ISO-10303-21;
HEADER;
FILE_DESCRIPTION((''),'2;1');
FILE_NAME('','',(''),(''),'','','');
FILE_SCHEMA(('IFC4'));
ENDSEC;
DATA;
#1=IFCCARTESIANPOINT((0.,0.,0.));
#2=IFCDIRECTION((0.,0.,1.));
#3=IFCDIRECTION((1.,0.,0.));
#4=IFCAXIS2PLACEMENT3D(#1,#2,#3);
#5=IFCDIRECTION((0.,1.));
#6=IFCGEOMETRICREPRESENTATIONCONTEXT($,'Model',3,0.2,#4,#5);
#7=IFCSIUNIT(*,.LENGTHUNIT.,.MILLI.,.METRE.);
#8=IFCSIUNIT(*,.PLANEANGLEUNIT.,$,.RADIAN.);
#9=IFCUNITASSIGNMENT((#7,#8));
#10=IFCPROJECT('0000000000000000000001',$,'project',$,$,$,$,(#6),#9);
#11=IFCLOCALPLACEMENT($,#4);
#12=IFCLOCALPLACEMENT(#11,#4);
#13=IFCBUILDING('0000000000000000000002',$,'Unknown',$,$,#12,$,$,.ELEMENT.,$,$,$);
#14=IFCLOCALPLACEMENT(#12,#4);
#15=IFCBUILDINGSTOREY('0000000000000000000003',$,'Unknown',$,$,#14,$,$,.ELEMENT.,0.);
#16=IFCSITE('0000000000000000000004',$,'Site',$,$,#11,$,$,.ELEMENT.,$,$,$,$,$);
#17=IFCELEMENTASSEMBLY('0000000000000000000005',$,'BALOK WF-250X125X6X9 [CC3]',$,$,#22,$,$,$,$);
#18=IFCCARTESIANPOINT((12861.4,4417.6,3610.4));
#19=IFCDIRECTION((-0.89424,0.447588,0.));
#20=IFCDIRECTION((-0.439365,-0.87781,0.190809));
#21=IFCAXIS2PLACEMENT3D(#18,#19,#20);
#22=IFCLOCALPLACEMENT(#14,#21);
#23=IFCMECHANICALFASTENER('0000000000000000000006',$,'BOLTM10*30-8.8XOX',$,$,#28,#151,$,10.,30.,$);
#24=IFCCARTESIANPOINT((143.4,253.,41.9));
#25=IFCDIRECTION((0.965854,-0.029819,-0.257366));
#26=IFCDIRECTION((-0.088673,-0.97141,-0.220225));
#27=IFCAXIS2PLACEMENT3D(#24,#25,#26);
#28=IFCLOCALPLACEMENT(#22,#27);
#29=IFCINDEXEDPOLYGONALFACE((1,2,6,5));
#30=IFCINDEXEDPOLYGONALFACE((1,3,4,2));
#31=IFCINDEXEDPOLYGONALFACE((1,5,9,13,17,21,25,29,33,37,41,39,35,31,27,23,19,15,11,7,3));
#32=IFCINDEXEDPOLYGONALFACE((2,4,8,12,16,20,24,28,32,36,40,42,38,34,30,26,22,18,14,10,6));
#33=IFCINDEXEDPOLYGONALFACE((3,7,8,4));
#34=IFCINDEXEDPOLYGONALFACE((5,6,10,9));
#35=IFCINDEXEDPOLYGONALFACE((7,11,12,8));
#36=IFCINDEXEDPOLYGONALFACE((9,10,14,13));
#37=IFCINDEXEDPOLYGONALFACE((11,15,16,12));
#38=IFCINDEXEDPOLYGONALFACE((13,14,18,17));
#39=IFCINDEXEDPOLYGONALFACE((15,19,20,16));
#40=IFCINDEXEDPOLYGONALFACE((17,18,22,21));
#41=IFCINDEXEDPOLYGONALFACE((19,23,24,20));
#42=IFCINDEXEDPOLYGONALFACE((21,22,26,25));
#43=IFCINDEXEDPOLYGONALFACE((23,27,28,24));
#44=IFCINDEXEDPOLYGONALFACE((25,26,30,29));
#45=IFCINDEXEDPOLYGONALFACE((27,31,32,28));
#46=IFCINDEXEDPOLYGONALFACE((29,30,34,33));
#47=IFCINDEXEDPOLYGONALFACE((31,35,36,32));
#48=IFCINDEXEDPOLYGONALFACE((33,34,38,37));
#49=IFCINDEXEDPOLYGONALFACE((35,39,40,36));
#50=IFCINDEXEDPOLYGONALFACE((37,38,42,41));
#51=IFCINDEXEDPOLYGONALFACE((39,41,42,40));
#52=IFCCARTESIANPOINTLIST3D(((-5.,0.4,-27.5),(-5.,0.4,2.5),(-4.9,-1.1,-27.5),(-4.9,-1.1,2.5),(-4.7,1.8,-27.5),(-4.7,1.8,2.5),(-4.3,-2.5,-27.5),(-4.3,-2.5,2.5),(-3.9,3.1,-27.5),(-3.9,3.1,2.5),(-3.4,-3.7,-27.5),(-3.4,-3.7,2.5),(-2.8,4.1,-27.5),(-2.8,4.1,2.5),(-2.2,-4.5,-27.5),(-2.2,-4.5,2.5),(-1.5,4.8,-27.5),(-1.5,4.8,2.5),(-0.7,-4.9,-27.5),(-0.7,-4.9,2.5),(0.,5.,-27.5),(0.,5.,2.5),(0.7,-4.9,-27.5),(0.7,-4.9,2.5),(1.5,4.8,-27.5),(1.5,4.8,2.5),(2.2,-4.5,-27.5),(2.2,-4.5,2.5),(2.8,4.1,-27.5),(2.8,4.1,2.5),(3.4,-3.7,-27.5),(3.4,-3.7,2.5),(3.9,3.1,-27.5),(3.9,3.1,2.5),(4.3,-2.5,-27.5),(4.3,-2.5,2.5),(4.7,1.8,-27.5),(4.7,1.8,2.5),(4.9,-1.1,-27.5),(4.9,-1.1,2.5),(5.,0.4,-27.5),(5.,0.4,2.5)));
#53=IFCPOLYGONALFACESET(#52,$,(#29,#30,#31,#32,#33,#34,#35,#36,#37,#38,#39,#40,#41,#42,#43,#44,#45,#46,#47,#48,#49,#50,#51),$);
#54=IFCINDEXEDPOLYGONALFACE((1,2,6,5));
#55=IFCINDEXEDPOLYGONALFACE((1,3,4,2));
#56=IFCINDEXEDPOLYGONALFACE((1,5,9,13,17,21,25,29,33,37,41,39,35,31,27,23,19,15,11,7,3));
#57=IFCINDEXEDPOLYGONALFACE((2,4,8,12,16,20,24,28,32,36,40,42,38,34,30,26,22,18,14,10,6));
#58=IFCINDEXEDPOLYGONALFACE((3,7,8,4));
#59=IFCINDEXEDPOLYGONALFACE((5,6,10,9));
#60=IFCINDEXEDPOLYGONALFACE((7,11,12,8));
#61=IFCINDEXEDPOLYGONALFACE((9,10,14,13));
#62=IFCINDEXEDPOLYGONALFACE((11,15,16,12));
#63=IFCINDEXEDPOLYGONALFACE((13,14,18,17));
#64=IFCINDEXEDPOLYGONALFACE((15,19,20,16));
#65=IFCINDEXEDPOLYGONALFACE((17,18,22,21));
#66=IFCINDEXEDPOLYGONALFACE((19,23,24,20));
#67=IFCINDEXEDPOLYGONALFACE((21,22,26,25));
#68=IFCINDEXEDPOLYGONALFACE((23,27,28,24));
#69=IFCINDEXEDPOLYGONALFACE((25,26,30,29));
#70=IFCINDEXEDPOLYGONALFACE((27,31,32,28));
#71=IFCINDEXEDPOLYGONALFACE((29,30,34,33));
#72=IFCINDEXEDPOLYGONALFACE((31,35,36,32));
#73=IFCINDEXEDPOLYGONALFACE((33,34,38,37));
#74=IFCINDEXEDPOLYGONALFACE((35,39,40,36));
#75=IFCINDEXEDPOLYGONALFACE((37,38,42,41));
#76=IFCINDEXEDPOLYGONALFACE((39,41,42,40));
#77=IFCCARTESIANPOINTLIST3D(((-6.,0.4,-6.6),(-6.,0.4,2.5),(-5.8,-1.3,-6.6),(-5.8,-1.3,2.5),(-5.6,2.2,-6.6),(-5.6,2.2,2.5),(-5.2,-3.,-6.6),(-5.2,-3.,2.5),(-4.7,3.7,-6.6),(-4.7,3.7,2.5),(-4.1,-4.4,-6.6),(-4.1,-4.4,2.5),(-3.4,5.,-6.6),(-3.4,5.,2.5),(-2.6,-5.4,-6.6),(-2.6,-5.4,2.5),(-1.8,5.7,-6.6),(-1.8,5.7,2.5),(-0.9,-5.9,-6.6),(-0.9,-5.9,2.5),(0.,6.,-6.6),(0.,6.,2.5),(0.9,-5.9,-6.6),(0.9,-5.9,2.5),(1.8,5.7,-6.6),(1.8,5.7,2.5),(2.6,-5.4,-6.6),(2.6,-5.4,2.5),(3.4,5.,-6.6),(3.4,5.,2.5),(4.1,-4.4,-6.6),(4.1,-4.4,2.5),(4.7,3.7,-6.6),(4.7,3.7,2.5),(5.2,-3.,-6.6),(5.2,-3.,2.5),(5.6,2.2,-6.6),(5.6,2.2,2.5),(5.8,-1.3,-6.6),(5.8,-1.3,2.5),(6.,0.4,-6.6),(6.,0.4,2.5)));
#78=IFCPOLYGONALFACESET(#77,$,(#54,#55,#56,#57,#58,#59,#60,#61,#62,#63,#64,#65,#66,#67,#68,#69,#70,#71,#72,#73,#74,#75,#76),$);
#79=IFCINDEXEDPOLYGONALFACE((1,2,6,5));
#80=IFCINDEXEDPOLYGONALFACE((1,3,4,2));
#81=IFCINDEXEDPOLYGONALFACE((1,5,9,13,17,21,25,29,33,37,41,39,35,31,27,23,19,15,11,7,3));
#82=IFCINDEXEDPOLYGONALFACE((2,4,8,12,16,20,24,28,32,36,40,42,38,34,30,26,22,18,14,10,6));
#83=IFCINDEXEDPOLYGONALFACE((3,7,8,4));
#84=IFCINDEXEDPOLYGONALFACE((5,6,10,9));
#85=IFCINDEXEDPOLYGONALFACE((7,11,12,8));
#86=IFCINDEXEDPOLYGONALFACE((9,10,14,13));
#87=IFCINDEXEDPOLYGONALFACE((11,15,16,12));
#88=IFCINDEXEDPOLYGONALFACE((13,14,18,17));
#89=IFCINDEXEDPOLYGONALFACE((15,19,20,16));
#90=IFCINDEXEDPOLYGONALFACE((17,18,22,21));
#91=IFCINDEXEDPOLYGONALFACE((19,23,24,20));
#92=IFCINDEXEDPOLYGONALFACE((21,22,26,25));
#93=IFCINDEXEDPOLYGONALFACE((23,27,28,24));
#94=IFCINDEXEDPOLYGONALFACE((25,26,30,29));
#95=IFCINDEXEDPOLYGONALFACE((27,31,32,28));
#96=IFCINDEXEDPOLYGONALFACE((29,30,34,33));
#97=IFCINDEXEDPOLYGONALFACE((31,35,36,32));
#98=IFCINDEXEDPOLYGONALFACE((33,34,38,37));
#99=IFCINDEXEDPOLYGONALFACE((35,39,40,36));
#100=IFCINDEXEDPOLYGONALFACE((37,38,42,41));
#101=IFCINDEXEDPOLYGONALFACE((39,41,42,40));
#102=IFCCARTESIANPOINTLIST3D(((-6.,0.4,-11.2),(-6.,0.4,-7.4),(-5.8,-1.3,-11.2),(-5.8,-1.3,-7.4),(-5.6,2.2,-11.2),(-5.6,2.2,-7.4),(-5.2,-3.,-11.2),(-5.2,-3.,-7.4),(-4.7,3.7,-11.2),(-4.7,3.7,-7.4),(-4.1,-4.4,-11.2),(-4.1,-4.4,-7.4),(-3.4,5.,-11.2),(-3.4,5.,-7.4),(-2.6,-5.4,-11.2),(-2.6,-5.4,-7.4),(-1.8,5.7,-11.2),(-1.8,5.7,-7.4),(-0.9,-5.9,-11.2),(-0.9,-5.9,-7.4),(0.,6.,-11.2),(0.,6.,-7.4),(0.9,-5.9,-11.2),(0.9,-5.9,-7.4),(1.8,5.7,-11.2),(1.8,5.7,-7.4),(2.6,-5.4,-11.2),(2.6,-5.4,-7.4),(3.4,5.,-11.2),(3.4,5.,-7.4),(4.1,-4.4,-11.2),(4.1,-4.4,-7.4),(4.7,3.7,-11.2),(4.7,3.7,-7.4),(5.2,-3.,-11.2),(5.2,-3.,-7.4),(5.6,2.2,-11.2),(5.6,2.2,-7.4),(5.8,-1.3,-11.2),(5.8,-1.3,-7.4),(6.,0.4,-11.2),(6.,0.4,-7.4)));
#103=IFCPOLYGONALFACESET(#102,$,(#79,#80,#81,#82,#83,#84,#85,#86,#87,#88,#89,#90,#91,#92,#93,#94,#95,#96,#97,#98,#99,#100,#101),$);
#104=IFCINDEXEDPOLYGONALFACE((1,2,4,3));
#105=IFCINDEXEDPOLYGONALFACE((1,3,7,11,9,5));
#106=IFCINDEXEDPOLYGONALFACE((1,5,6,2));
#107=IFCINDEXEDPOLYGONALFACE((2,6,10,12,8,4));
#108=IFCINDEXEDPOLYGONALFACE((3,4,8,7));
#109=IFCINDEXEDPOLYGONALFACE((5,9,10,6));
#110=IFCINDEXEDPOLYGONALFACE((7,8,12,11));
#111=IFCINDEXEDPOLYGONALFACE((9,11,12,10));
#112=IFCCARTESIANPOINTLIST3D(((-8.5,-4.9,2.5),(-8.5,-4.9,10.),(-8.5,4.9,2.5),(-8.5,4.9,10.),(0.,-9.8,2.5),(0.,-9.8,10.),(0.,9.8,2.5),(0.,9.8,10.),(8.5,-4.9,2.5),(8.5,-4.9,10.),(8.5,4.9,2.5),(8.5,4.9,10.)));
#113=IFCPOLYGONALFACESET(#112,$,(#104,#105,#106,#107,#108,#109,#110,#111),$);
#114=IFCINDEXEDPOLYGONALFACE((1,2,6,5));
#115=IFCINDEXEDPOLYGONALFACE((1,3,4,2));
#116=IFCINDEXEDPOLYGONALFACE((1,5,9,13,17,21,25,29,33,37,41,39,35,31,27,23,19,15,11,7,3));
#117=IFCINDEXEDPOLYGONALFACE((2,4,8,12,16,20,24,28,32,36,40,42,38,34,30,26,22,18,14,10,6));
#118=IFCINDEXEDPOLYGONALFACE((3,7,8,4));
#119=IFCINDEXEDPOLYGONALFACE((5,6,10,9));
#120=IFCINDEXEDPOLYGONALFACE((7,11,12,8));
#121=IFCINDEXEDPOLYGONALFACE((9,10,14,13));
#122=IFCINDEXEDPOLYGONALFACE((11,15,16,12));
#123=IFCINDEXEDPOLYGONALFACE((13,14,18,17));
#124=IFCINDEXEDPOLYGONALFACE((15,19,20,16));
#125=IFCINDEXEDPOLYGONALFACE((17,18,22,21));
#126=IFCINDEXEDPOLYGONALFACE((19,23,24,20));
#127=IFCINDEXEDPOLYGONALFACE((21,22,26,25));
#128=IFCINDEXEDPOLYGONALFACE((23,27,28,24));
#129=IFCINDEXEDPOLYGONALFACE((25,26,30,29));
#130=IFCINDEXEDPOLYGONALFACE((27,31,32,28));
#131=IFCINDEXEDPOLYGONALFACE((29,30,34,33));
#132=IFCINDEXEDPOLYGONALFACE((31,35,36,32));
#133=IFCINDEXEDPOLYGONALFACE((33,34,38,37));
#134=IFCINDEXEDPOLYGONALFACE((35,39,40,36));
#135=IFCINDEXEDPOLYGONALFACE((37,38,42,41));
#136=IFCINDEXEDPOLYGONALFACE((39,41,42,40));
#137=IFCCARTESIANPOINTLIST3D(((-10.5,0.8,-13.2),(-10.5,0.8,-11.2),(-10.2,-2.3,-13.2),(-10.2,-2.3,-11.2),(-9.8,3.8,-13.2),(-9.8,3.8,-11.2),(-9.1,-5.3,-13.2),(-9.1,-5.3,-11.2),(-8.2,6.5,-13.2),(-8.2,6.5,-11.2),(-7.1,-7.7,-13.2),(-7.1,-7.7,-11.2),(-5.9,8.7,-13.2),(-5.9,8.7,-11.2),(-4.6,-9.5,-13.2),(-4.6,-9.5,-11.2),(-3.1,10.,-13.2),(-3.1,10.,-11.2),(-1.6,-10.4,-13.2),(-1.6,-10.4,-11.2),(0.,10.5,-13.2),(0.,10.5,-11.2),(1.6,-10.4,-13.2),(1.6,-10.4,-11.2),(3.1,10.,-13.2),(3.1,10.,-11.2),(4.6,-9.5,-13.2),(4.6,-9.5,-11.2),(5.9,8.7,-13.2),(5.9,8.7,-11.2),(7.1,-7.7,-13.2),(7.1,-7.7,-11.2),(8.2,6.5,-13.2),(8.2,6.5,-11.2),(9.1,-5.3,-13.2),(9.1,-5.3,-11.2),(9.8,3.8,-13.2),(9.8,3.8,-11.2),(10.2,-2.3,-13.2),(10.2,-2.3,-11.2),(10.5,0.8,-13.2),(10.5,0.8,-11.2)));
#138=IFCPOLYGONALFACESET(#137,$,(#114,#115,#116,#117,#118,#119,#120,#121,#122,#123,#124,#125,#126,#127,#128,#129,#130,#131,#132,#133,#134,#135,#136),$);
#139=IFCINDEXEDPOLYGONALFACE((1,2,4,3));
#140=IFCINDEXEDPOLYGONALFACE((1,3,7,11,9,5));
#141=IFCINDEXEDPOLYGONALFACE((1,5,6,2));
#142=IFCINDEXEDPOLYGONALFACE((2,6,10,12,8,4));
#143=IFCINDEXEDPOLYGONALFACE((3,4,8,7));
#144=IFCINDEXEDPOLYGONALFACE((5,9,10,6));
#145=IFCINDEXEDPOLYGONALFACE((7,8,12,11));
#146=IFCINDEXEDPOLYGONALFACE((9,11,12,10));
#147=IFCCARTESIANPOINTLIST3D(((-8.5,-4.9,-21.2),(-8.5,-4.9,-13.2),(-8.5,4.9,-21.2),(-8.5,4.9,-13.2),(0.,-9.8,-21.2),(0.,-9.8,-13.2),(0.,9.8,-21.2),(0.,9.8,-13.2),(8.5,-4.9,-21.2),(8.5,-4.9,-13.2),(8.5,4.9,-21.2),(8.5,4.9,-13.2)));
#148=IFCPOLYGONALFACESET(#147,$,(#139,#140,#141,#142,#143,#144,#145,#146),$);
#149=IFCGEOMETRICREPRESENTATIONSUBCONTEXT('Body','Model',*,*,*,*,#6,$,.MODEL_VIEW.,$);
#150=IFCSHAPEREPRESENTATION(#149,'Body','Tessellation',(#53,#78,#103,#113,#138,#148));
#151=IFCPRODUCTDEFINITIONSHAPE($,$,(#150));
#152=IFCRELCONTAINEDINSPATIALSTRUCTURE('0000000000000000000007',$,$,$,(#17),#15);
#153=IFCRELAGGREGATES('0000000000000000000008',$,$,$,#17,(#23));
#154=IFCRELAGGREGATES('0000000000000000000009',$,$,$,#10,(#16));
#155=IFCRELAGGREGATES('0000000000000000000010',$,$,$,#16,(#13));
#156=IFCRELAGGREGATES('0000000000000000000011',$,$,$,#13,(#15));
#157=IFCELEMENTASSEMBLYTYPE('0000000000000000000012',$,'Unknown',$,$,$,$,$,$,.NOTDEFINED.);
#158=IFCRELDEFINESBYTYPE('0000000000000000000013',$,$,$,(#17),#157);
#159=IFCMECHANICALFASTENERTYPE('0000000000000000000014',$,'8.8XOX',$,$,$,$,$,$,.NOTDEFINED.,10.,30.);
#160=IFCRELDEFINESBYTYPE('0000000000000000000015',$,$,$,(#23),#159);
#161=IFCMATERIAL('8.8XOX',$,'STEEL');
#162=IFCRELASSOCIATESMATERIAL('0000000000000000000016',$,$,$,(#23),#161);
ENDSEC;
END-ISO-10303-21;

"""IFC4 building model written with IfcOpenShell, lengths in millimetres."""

from ifc_helpers import new_model, si_unit, direction, frame, origin_with_axes, origin_2d_with_axis, place, context, subcontext, project, spatial, polyline, circle, outline, extrude, source, transform, mapped, material, type_object, element, aggregate, save


model = new_model("IFC4")

# Units and contexts
model_context = context("Model", 3, precision=0.2, world=origin_with_axes(), true_north=direction((0.0, 1.0)))
body_context = subcontext(model_context, "Body", "Model", "MODEL_VIEW")
ifc_project = project(units=[si_unit("LENGTHUNIT", "METRE", prefix="MILLI"), si_unit("PLANEANGLEUNIT", "RADIAN")], contexts=[model_context])

# Site, building, storey
site_placement = place(None, origin_with_axes())
site = spatial("IfcSite", under=ifc_project, at=site_placement, Name="Site", CompositionType="ELEMENT")
building_placement = place(site_placement, origin_with_axes())
building = spatial("IfcBuilding", under=site, at=building_placement, Name="Unknown", CompositionType="ELEMENT")
storey_placement = place(building_placement, origin_with_axes())
storey = spatial("IfcBuildingStorey", under=building, at=storey_placement, Name="Unknown", CompositionType="ELEMENT", Elevation=0.0)

# Element assembly
element_assembly_type = type_object("IfcElementAssemblyType", Name="Unknown", PredefinedType="NOTDEFINED")
assembly_1_placement = place(storey_placement, frame((12861.4, 4417.6, 3610.4), z_axis=(-0.89424, 0.447588, 0.0), x_axis=(-0.439365, -0.87781, 0.190809)))
assembly_1 = element("IfcElementAssembly", 1, at=assembly_1_placement, inside=storey, type_object=element_assembly_type, Name="BALOK WF-250X125X6X9 [CC3]")

# Mechanical fastener
ifc_material_1 = material(Name="8.8XOX", Category="STEEL")
mechanical_fastener_type_1 = type_object("IfcMechanicalFastenerType", Name="8.8XOX", NominalDiameter=10.0, NominalLength=30.0, PredefinedType="NOTDEFINED")
shared_shape_1 = source(origin_with_axes(), body_context, "Body", "SweptSolid", [
    extrude(circle(Radius=5.0, at=origin_2d_with_axis()), frame((0.0, 0.0, 2.5), z_axis=(0.0, 0.0, -1.0), x_axis=(0.0, 1.0, 0.0)), (0.0, 0.0, 1.0), 30.0),
    extrude(circle(Radius=6.0, at=origin_2d_with_axis()), frame((0.0, 0.0, 2.5), z_axis=(0.0, 0.0, -1.0), x_axis=(0.0, 1.0, 0.0)), (0.0, 0.0, 1.0), 9.1),
    extrude(circle(Radius=6.0, at=origin_2d_with_axis()), frame((0.0, 0.0, -7.4), z_axis=(0.0, 0.0, -1.0), x_axis=(0.0, 1.0, 0.0)), (0.0, 0.0, 1.0), 3.8),
    extrude(outline(polyline([(9.8, 0.0), (4.9, 8.5), (-4.9, 8.5), (-9.8, 0.0), (-4.9, -8.5), (4.9, -8.5), (9.8, 0.0)])), frame((0.0, 0.0, 10.0), z_axis=(0.0, 0.0, -1.0), x_axis=(0.0, 1.0, 0.0)), (0.0, 0.0, 1.0), 7.5),
    extrude(circle(Radius=10.5, at=origin_2d_with_axis()), frame((0.0, 0.0, -11.2), z_axis=(0.0, 0.0, -1.0), x_axis=(0.0, 1.0, 0.0)), (0.0, 0.0, 1.0), 2.0),
    extrude(outline(polyline([(9.8, 0.0), (4.9, 8.5), (-4.9, 8.5), (-9.8, 0.0), (-4.9, -8.5), (4.9, -8.5), (9.8, 0.0)])), frame((0.0, 0.0, -13.2), z_axis=(0.0, 0.0, -1.0), x_axis=(0.0, 1.0, 0.0)), (0.0, 0.0, 1.0), 8.0),
])
mechanical_fastener_1_placement = place(assembly_1_placement, frame((143.4, 253.0, 41.9), z_axis=(0.965854, -0.029819, -0.257366), x_axis=(-0.088673, -0.97141, -0.220225)))
mechanical_fastener_1 = element("IfcMechanicalFastener", 2, at=mechanical_fastener_1_placement, type_object=mechanical_fastener_type_1, material=ifc_material_1, Name="BOLTM10*30-8.8XOX", NominalDiameter=10.0, NominalLength=30.0, context=body_context, shape_type="MappedRepresentation", body=[
    mapped(shared_shape_1, transform((0.0, 0.0, 0.0))),
])
aggregate(assembly_1, [mechanical_fastener_1])

save(model, "model.ifc")
